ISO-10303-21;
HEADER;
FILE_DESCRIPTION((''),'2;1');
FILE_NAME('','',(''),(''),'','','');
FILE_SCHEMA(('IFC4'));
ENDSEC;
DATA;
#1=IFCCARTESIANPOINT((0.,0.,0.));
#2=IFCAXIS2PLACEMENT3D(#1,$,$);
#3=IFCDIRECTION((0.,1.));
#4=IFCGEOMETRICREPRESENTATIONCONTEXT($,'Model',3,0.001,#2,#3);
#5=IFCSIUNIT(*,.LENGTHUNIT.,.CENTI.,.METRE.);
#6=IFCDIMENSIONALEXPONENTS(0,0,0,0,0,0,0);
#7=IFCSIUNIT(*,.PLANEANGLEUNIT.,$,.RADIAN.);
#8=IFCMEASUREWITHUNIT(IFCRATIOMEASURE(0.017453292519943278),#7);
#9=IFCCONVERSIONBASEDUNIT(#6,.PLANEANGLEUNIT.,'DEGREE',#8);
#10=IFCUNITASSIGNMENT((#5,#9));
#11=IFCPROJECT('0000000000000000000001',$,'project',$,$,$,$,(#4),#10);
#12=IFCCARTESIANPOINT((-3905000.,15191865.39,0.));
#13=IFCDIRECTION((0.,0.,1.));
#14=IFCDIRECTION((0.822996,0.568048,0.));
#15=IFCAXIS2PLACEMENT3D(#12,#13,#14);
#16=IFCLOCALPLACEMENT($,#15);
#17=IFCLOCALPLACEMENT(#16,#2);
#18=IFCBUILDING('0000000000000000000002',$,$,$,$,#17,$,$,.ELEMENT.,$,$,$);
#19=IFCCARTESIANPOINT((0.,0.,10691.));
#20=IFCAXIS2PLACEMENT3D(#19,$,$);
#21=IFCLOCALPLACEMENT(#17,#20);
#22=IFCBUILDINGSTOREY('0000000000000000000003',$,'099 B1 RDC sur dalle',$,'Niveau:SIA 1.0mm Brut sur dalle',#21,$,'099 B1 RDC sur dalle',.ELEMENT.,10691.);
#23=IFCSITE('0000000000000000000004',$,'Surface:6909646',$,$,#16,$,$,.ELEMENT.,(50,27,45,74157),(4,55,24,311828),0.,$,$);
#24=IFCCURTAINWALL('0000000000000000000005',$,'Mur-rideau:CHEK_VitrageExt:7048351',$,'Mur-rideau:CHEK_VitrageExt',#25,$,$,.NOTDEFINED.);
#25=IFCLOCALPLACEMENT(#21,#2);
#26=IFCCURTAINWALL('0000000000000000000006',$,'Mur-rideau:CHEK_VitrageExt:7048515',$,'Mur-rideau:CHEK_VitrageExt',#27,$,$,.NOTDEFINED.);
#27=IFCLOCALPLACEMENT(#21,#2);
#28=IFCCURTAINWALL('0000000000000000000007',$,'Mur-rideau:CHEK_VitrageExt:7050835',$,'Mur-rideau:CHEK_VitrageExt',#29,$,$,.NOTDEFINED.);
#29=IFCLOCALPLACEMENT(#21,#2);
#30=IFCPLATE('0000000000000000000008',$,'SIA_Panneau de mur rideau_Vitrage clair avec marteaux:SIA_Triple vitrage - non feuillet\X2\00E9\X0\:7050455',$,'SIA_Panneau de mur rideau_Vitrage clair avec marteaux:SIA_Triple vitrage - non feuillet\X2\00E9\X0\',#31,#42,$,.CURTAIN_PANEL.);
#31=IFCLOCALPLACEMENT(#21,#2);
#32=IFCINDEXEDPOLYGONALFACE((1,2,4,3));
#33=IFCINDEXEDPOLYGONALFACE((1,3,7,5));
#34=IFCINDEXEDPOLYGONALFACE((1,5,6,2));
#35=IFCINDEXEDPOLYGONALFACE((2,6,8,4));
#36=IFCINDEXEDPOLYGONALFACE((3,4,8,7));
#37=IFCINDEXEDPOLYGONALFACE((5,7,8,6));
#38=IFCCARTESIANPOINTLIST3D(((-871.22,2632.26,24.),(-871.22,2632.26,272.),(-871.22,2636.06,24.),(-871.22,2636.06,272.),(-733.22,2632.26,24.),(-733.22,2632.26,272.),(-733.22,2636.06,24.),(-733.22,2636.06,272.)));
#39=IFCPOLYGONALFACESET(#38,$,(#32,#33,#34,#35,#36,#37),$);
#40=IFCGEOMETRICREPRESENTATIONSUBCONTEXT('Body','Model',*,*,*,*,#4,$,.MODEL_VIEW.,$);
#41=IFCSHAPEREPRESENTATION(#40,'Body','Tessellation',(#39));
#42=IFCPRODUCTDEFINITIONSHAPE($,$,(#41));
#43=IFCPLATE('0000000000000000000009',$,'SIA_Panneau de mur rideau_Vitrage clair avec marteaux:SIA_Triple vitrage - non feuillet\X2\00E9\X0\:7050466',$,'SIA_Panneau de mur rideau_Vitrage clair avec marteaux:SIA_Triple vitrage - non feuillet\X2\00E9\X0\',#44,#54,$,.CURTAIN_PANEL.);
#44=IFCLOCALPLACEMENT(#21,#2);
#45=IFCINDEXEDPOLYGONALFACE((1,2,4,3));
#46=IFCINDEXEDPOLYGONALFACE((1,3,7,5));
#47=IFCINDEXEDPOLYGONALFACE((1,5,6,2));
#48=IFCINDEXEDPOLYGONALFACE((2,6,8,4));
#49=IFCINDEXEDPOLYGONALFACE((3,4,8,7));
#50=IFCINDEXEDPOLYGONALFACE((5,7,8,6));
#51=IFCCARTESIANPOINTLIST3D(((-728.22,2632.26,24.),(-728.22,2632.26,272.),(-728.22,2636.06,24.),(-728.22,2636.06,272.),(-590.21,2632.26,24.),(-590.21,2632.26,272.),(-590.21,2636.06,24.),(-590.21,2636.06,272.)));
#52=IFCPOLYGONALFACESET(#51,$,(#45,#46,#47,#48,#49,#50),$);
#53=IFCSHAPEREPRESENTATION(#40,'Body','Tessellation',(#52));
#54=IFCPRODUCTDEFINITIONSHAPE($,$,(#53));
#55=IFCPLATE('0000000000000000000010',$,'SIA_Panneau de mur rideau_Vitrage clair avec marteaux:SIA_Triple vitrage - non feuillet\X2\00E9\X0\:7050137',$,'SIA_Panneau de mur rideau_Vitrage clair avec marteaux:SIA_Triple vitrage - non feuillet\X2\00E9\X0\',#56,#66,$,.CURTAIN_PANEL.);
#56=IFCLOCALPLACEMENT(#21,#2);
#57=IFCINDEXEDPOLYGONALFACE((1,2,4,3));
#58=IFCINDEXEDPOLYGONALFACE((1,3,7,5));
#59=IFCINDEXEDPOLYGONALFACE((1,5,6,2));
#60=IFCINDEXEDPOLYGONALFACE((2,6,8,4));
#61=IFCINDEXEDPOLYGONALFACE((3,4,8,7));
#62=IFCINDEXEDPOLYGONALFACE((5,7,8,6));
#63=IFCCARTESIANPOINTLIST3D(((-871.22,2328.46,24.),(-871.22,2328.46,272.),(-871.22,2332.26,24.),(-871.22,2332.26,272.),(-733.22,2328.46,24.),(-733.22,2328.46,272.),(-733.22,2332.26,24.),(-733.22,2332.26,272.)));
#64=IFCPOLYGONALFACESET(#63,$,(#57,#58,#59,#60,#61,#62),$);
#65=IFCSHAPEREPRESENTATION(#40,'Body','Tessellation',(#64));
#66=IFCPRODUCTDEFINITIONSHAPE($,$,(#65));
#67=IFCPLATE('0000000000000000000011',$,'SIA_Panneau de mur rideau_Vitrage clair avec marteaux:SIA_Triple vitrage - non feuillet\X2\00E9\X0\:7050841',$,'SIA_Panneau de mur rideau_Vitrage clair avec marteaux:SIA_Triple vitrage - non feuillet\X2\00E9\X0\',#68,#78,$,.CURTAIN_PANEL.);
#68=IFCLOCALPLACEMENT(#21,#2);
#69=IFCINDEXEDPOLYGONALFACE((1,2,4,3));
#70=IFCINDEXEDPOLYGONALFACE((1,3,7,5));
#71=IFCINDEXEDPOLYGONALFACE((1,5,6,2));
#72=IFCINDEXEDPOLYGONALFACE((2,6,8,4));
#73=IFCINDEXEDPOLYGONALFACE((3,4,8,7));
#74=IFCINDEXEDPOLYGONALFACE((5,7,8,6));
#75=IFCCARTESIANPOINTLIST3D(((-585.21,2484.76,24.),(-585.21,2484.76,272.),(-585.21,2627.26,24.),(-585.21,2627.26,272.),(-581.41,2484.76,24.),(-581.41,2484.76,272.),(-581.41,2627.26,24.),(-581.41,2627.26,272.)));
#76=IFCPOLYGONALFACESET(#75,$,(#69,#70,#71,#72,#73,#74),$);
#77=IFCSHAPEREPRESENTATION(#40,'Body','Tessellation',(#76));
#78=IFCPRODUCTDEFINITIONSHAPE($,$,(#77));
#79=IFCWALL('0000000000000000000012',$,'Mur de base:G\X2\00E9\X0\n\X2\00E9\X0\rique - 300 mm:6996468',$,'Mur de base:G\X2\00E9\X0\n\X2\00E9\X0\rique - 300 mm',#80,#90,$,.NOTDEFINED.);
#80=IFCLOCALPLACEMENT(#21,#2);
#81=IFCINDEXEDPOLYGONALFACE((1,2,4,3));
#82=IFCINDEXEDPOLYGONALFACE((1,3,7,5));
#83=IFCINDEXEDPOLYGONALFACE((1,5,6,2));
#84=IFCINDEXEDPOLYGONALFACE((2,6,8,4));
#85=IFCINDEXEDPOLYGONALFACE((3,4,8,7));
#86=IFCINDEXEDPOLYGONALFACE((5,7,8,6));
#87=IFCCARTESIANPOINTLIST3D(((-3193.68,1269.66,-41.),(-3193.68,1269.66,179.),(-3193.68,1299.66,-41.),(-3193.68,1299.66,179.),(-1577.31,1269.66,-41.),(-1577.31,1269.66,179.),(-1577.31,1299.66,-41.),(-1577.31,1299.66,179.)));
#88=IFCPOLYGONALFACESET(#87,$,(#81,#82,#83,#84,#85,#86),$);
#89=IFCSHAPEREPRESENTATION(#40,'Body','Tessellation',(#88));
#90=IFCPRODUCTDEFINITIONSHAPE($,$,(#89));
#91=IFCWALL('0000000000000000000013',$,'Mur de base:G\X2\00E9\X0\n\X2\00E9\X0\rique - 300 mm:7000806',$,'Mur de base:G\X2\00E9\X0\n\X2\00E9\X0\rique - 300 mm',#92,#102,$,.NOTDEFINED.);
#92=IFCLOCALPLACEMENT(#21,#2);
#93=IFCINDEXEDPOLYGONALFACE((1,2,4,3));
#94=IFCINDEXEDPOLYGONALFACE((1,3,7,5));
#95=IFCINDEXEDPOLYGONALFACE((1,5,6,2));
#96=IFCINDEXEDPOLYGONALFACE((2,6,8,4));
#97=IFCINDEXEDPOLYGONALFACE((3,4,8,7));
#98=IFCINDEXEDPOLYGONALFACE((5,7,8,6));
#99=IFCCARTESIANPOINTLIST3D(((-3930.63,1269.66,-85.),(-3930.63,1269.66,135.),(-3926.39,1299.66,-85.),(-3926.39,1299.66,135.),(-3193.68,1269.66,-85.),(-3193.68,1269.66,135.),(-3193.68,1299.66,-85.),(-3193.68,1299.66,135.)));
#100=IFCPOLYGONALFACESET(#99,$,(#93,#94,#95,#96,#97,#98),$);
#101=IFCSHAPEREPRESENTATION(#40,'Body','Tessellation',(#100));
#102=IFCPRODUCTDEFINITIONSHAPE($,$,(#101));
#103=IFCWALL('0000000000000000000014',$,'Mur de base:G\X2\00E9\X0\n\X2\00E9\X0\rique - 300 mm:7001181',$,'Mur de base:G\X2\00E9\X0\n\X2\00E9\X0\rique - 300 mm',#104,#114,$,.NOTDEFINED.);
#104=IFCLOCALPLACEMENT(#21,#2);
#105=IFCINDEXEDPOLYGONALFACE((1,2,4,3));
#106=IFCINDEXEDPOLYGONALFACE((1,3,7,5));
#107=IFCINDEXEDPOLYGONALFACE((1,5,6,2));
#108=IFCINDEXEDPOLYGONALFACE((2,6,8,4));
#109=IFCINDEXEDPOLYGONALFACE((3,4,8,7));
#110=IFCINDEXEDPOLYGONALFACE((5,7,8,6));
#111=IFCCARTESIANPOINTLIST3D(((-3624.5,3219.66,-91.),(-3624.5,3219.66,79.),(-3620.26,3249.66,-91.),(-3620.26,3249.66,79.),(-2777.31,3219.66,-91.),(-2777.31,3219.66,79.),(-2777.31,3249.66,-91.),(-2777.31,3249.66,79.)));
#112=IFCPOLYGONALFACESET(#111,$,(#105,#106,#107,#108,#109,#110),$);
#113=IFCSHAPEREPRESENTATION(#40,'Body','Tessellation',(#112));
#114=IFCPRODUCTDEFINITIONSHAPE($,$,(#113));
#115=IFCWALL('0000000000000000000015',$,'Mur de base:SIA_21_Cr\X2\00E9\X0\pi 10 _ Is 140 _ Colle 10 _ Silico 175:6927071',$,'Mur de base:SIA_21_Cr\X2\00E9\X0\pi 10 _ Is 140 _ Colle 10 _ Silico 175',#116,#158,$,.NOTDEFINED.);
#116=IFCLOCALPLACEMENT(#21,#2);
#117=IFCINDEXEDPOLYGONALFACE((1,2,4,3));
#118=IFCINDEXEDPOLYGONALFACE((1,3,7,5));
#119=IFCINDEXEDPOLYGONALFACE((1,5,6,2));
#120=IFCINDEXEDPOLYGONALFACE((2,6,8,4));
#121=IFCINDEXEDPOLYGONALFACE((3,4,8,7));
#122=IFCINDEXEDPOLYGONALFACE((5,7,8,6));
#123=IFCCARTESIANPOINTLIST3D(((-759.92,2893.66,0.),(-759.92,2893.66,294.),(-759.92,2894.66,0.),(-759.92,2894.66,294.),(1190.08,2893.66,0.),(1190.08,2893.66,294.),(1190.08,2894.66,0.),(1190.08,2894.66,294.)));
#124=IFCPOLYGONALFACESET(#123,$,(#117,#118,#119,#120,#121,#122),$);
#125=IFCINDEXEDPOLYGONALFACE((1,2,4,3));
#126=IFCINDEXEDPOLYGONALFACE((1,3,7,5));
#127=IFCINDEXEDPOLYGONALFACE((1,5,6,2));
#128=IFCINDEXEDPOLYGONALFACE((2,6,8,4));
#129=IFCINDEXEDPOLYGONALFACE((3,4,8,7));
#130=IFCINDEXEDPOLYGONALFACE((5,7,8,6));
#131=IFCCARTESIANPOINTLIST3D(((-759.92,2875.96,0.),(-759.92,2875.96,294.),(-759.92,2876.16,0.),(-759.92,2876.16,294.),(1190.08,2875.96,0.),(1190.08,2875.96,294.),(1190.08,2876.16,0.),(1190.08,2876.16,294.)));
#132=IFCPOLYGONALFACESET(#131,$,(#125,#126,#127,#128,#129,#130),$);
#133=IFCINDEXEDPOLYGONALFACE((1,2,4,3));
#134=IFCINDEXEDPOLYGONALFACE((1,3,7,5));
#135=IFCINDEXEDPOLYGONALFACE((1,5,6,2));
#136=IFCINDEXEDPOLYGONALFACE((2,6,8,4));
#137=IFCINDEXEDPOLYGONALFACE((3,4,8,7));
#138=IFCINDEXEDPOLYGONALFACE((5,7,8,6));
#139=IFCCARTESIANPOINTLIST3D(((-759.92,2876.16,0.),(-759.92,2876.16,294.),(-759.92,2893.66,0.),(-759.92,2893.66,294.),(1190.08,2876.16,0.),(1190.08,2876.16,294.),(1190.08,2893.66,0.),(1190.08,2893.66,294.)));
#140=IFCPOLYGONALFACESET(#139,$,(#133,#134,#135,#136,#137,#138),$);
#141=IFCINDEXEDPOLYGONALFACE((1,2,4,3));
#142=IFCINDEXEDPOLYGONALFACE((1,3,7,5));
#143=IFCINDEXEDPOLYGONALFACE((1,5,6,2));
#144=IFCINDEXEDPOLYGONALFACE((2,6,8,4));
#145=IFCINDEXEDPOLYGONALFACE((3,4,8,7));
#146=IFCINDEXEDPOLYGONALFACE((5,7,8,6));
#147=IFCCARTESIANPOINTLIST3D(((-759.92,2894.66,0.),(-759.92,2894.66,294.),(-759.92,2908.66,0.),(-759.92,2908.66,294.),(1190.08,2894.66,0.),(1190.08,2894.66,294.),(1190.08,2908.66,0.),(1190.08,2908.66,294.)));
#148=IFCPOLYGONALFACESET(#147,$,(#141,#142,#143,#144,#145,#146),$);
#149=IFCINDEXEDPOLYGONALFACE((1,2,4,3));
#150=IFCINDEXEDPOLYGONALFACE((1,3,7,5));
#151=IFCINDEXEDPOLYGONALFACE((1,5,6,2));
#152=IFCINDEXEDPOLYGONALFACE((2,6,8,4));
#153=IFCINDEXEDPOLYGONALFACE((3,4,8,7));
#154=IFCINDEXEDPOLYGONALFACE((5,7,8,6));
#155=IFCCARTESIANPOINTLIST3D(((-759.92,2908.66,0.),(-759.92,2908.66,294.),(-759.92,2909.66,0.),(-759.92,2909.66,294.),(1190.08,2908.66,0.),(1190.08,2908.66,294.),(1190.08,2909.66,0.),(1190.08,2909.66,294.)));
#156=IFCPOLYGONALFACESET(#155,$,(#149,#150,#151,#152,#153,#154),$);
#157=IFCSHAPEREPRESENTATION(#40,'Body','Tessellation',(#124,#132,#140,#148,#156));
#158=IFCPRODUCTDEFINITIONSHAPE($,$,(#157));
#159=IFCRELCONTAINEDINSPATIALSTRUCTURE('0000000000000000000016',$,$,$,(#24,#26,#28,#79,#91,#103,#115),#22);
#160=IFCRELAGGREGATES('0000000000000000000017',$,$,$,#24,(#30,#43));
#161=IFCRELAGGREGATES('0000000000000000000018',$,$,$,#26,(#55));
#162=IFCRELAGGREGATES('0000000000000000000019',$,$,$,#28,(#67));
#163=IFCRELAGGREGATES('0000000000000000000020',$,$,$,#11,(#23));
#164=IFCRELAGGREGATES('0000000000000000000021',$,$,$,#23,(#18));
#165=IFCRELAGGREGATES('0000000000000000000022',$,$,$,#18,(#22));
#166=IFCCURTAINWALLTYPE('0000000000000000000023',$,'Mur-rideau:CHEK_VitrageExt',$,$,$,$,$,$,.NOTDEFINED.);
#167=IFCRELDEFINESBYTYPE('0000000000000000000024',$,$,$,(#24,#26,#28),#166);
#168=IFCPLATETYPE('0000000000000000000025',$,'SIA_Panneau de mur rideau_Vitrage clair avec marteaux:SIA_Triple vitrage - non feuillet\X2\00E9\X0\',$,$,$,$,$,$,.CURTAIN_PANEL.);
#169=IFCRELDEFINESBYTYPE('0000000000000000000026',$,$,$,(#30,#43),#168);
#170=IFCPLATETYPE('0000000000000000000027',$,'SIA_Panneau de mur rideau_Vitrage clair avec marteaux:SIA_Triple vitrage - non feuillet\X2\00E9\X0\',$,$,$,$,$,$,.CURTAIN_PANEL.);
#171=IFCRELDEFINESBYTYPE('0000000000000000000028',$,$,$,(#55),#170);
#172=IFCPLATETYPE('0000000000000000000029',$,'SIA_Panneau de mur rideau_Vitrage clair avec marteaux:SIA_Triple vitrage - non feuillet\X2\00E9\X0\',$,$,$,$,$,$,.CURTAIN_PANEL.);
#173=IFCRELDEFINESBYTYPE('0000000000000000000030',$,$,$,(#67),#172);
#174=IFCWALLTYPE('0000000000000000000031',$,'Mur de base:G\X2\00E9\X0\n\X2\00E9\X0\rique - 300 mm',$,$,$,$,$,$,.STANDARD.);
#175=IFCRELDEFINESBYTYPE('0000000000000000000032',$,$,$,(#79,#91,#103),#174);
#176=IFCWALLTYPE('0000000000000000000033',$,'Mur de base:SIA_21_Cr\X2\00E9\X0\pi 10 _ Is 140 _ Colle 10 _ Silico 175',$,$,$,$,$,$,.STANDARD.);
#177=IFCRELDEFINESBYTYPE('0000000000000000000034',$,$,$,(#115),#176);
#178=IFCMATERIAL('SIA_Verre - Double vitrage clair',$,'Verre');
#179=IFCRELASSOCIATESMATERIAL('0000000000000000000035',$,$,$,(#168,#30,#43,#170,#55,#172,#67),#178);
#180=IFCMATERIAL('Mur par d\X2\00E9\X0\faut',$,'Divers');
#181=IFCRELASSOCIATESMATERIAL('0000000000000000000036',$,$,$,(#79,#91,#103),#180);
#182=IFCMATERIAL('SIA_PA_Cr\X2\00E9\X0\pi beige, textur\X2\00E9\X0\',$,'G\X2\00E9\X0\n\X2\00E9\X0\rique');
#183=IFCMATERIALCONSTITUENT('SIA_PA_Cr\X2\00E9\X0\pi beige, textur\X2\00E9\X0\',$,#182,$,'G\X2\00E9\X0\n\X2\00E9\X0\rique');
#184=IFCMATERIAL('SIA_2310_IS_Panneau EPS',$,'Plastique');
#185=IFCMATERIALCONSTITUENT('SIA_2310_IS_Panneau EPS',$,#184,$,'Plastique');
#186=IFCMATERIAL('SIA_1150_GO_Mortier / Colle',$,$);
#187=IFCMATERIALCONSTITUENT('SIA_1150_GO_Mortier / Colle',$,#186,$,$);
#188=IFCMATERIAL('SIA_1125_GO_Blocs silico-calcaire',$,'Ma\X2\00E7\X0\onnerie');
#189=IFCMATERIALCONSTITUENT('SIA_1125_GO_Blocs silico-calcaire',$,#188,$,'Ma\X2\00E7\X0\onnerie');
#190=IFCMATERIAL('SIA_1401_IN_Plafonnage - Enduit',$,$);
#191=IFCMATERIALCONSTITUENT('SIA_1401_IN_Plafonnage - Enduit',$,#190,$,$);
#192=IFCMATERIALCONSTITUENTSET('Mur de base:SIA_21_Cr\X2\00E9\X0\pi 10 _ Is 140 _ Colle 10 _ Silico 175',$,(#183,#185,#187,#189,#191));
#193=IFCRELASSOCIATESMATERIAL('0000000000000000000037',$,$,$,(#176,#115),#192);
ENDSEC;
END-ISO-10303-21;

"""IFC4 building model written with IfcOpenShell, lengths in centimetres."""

from ifc_helpers import new_model, entity, si_unit, converted_unit, direction, frame, origin, place, context, subcontext, project, spatial, indexed_curve, outline, extrude, source, transform, mapped, material, constituent, constituent_set, type_object, type_shapes, element, aggregate, save


model = new_model("IFC4")

# Units and contexts
model_context = context("Model", 3, precision=0.001, world=origin(), true_north=direction((0.0, 1.0)))
body_context = subcontext(model_context, "Body", "Model", "MODEL_VIEW")
ifc_project = project(units=[si_unit("LENGTHUNIT", "METRE", prefix="CENTI"), converted_unit("PLANEANGLEUNIT", "DEGREE", entity("IfcRatioMeasure", 0.017453292519943278), si_unit("PLANEANGLEUNIT", "RADIAN"), dimensions=[0, 0, 0, 0, 0, 0, 0])], contexts=[model_context])

# Site, building, storey
site_placement = place(None, frame((-3905000.0, 15191865.39, 0.0), z_axis=(0.0, 0.0, 1.0), x_axis=(0.822996, 0.568048, 0.0)))
site = spatial("IfcSite", under=ifc_project, at=site_placement, Name="Surface:6909646", CompositionType="ELEMENT", RefLatitude=(50, 27, 45, 74157), RefLongitude=(4, 55, 24, 311828), RefElevation=0.0)
building_placement = place(site_placement, origin())
building = spatial("IfcBuilding", under=site, at=building_placement, CompositionType="ELEMENT")
storey_placement = place(building_placement, frame((0.0, 0.0, 10691.0)))
storey = spatial("IfcBuildingStorey", under=building, at=storey_placement, Name="099 B1 RDC sur dalle", ObjectType="Niveau:SIA 1.0mm Brut sur dalle", LongName="099 B1 RDC sur dalle", CompositionType="ELEMENT", Elevation=10691.0)

# Curtain walls
curtain_wall_type = type_object("IfcCurtainWallType", Name="Mur-rideau:CHEK_VitrageExt", PredefinedType="NOTDEFINED")
curtain_wall_1_placement = place(storey_placement, frame((0.0, 0.0, -10691.0)))
curtain_wall_1 = element("IfcCurtainWall", 1, at=curtain_wall_1_placement, inside=storey, type_object=curtain_wall_type, Name="Mur-rideau:CHEK_VitrageExt:7048351", ObjectType="Mur-rideau:CHEK_VitrageExt", PredefinedType="NOTDEFINED")
curtain_wall_2_placement = place(storey_placement, frame((0.0, 0.0, -10691.0)))
curtain_wall_2 = element("IfcCurtainWall", 2, at=curtain_wall_2_placement, inside=storey, type_object=curtain_wall_type, Name="Mur-rideau:CHEK_VitrageExt:7048515", ObjectType="Mur-rideau:CHEK_VitrageExt", PredefinedType="NOTDEFINED")

# Curtain wall
curtain_wall_3_placement = place(storey_placement, frame((0.0, 0.0, -10691.0)))
curtain_wall_3 = element("IfcCurtainWall", 3, at=curtain_wall_3_placement, inside=storey, type_object=curtain_wall_type, Name="Mur-rideau:CHEK_VitrageExt:7050835", ObjectType="Mur-rideau:CHEK_VitrageExt", PredefinedType="NOTDEFINED")

# Plates
ifc_material_1 = material(Name="SIA_Verre - Double vitrage clair", Category="Verre")
plate_type_1 = type_object("IfcPlateType", Name="SIA_Panneau de mur rideau_Vitrage clair avec marteaux:SIA_Triple vitrage - non feuilleté", PredefinedType="CURTAIN_PANEL", material=ifc_material_1)
shared_shape_1 = source(origin(), body_context, "Body", "SweptSolid", [
    extrude(outline(indexed_curve([(-69.0, -1.9), (69.0, -1.9), (69.0, 1.9), (-69.0, 1.9), (-69.0, -1.9)], self_intersect=False)), frame((0.0, 1.9, 0.0), z_axis=(0.0, 0.0, 1.0), x_axis=(-1.0, 0.0, 0.0)), (0.0, 0.0, 1.0), 248.0),
])
type_shapes(plate_type_1, [shared_shape_1])
plate_1_placement = place(curtain_wall_1_placement, frame((-802.22, 2632.26, 10715.0)))
plate_1 = element("IfcPlate", 4, at=plate_1_placement, type_object=plate_type_1, material=ifc_material_1, Name="SIA_Panneau de mur rideau_Vitrage clair avec marteaux:SIA_Triple vitrage - non feuilleté:7050455", ObjectType="SIA_Panneau de mur rideau_Vitrage clair avec marteaux:SIA_Triple vitrage - non feuilleté", PredefinedType="CURTAIN_PANEL", context=body_context, shape_type="MappedRepresentation", body=[
    mapped(shared_shape_1, transform((0.0, 0.0, 0.0), scale=1.0)),
])
plate_2_placement = place(curtain_wall_1_placement, frame((-659.21, 2632.26, 10715.0)))
plate_2 = element("IfcPlate", 5, at=plate_2_placement, type_object=plate_type_1, material=ifc_material_1, Name="SIA_Panneau de mur rideau_Vitrage clair avec marteaux:SIA_Triple vitrage - non feuilleté:7050466", ObjectType="SIA_Panneau de mur rideau_Vitrage clair avec marteaux:SIA_Triple vitrage - non feuilleté", PredefinedType="CURTAIN_PANEL", context=body_context, shape_type="MappedRepresentation", body=[
    mapped(shared_shape_1, transform((0.0, 0.0, 0.0), scale=1.0)),
])
aggregate(curtain_wall_1, [plate_1, plate_2])
plate_type_2 = type_object("IfcPlateType", Name="SIA_Panneau de mur rideau_Vitrage clair avec marteaux:SIA_Triple vitrage - non feuilleté", PredefinedType="CURTAIN_PANEL", material=ifc_material_1)
shared_shape_2 = source(origin(), body_context, "Body", "SweptSolid", [
    extrude(outline(indexed_curve([(-1.9, -69.0), (1.9, -69.0), (1.9, 69.0), (-1.9, 69.0), (-1.9, -69.0)], self_intersect=False)), frame((0.0, -1.9, 0.0), z_axis=(0.0, 0.0, 1.0), x_axis=(0.0, 1.0, 0.0)), (0.0, 0.0, 1.0), 248.0),
])
type_shapes(plate_type_2, [shared_shape_2])
plate_3_placement = place(curtain_wall_2_placement, frame((-802.22, 2332.26, 10715.0)))
plate_3 = element("IfcPlate", 6, at=plate_3_placement, type_object=plate_type_2, material=ifc_material_1, Name="SIA_Panneau de mur rideau_Vitrage clair avec marteaux:SIA_Triple vitrage - non feuilleté:7050137", ObjectType="SIA_Panneau de mur rideau_Vitrage clair avec marteaux:SIA_Triple vitrage - non feuilleté", PredefinedType="CURTAIN_PANEL", context=body_context, shape_type="MappedRepresentation", body=[
    mapped(shared_shape_2, transform((0.0, 0.0, 0.0), scale=1.0)),
])
aggregate(curtain_wall_2, [plate_3])
plate_type_3 = type_object("IfcPlateType", Name="SIA_Panneau de mur rideau_Vitrage clair avec marteaux:SIA_Triple vitrage - non feuilleté", PredefinedType="CURTAIN_PANEL", material=ifc_material_1)
shared_shape_3 = source(origin(), body_context, "Body", "SweptSolid", [
    extrude(outline(indexed_curve([(-1.9, -71.25), (1.9, -71.25), (1.9, 71.25), (-1.9, 71.25), (-1.9, -71.25)], self_intersect=False)), frame((0.0, -1.9, 0.0), z_axis=(0.0, 0.0, 1.0), x_axis=(0.0, 1.0, 0.0)), (0.0, 0.0, 1.0), 248.0),
])
type_shapes(plate_type_3, [shared_shape_3])
plate_4_placement = place(curtain_wall_3_placement, frame((-585.21, 2556.01, 10715.0), z_axis=(0.0, 0.0, 1.0), x_axis=(0.0, 1.0, 0.0)))
plate_4 = element("IfcPlate", 7, at=plate_4_placement, type_object=plate_type_3, material=ifc_material_1, Name="SIA_Panneau de mur rideau_Vitrage clair avec marteaux:SIA_Triple vitrage - non feuilleté:7050841", ObjectType="SIA_Panneau de mur rideau_Vitrage clair avec marteaux:SIA_Triple vitrage - non feuilleté", PredefinedType="CURTAIN_PANEL", context=body_context, shape_type="MappedRepresentation", body=[
    mapped(shared_shape_3, transform((0.0, 0.0, 0.0), scale=1.0)),
])
aggregate(curtain_wall_3, [plate_4])

# Walls
ifc_material_2 = material(Name="Mur par défaut", Category="Divers")
wall_type_1 = type_object("IfcWallType", Name="Mur de base:Générique - 300 mm", PredefinedType="STANDARD")
wall_1_placement = place(storey_placement, frame((-1577.31, 1284.66, -41.0), z_axis=(0.0, 0.0, 1.0), x_axis=(-1.0, 0.0, 0.0)))
element("IfcWall", 8, at=wall_1_placement, inside=storey, type_object=wall_type_1, material=ifc_material_2, Name="Mur de base:Générique - 300 mm:6996468", ObjectType="Mur de base:Générique - 300 mm", PredefinedType="NOTDEFINED", context=body_context, shape_type="SweptSolid", body=[
    extrude(outline(indexed_curve([(1616.37, 15.0), (0.0, 15.0), (0.0, -15.0), (1616.37, -15.0), (1616.37, 15.0)], self_intersect=False)), origin(), (0.0, 0.0, 1.0), 220.0),
])
wall_2_placement = place(storey_placement, frame((-3193.68, 1284.66, -85.0), z_axis=(0.0, 0.0, 1.0), x_axis=(-1.0, 0.0, 0.0)))
element("IfcWall", 9, at=wall_2_placement, inside=storey, type_object=wall_type_1, material=ifc_material_2, Name="Mur de base:Générique - 300 mm:7000806", ObjectType="Mur de base:Générique - 300 mm", PredefinedType="NOTDEFINED", context=body_context, shape_type="SweptSolid", body=[
    extrude(outline(indexed_curve([(732.71, -15.0), (736.95, 15.0), (0.0, 15.0), (0.0, -15.0), (732.71, -15.0)], self_intersect=False)), origin(), (0.0, 0.0, 1.0), 220.0),
])
wall_3_placement = place(storey_placement, frame((-2777.31, 3234.66, -91.0), z_axis=(0.0, 0.0, 1.0), x_axis=(-1.0, 0.0, 0.0)))
element("IfcWall", 10, at=wall_3_placement, inside=storey, type_object=wall_type_1, material=ifc_material_2, Name="Mur de base:Générique - 300 mm:7001181", ObjectType="Mur de base:Générique - 300 mm", PredefinedType="NOTDEFINED", context=body_context, shape_type="SweptSolid", body=[
    extrude(outline(indexed_curve([(842.95, -15.0), (847.2, 15.0), (0.0, 15.0), (0.0, -15.0), (842.95, -15.0)], self_intersect=False)), origin(), (0.0, 0.0, 1.0), 170.0),
])
ifc_material_3 = material(Name="SIA_PA_Crépi beige, texturé", Category="Générique")
ifc_constituent_1 = constituent(ifc_material_3, Name="SIA_PA_Crépi beige, texturé", Category="Générique")
ifc_material_4 = material(Name="SIA_2310_IS_Panneau EPS", Category="Plastique")
ifc_constituent_2 = constituent(ifc_material_4, Name="SIA_2310_IS_Panneau EPS", Category="Plastique")
ifc_material_5 = material(Name="SIA_1150_GO_Mortier / Colle")
ifc_constituent_3 = constituent(ifc_material_5, Name="SIA_1150_GO_Mortier / Colle")
ifc_material_6 = material(Name="SIA_1125_GO_Blocs silico-calcaire", Category="Maçonnerie")
ifc_constituent_4 = constituent(ifc_material_6, Name="SIA_1125_GO_Blocs silico-calcaire", Category="Maçonnerie")
ifc_material_7 = material(Name="SIA_1401_IN_Plafonnage - Enduit")
ifc_constituent_5 = constituent(ifc_material_7, Name="SIA_1401_IN_Plafonnage - Enduit")
ifc_constituent_set_1 = constituent_set(constituents=[ifc_constituent_1, ifc_constituent_2, ifc_constituent_3, ifc_constituent_4, ifc_constituent_5], Name="Mur de base:SIA_21_Crépi 10 _ Is 140 _ Colle 10 _ Silico 175")
wall_type_2 = type_object("IfcWallType", Name="Mur de base:SIA_21_Crépi 10 _ Is 140 _ Colle 10 _ Silico 175", PredefinedType="STANDARD", material=ifc_constituent_set_1)
wall_4_placement = place(storey_placement, frame((-759.92, 2892.81, 0.0)))
element("IfcWall", 11, at=wall_4_placement, inside=storey, type_object=wall_type_2, material=ifc_constituent_set_1, Name="Mur de base:SIA_21_Crépi 10 _ Is 140 _ Colle 10 _ Silico 175:6927071", ObjectType="Mur de base:SIA_21_Crépi 10 _ Is 140 _ Colle 10 _ Silico 175", PredefinedType="NOTDEFINED", context=body_context, shape_type="SweptSolid", body=[
    extrude(outline(indexed_curve([(-975.0, -0.5), (975.0, -0.5), (975.0, 0.5), (-975.0, 0.5), (-975.0, -0.5)], self_intersect=False)), frame((975.0, 1.35, 0.0)), (0.0, 0.0, 1.0), 294.0),
    extrude(outline(indexed_curve([(-0.1, -975.0), (0.1, -975.0), (0.1, 975.0), (-0.1, 975.0), (-0.1, -975.0)], self_intersect=False)), frame((975.0, -16.75, 0.0), z_axis=(0.0, 0.0, 1.0), x_axis=(0.0, 1.0, 0.0)), (0.0, 0.0, 1.0), 294.0),
    extrude(outline(indexed_curve([(-975.0, -8.75), (975.0, -8.75), (975.0, 8.75), (-975.0, 8.75), (-975.0, -8.75)], self_intersect=False)), frame((975.0, -7.9, 0.0)), (0.0, 0.0, 1.0), 294.0),
    extrude(outline(indexed_curve([(-975.0, -7.0), (975.0, -7.0), (975.0, 7.0), (-975.0, 7.0), (-975.0, -7.0)], self_intersect=False)), frame((975.0, 8.85, 0.0)), (0.0, 0.0, 1.0), 294.0),
    extrude(outline(indexed_curve([(-0.5, -975.0), (0.5, -975.0), (0.5, 975.0), (-0.5, 975.0), (-0.5, -975.0)], self_intersect=False)), frame((975.0, 16.35, 0.0), z_axis=(0.0, 0.0, 1.0), x_axis=(0.0, -1.0, 0.0)), (0.0, 0.0, 1.0), 294.0),
])

save(model, "model.ifc")
